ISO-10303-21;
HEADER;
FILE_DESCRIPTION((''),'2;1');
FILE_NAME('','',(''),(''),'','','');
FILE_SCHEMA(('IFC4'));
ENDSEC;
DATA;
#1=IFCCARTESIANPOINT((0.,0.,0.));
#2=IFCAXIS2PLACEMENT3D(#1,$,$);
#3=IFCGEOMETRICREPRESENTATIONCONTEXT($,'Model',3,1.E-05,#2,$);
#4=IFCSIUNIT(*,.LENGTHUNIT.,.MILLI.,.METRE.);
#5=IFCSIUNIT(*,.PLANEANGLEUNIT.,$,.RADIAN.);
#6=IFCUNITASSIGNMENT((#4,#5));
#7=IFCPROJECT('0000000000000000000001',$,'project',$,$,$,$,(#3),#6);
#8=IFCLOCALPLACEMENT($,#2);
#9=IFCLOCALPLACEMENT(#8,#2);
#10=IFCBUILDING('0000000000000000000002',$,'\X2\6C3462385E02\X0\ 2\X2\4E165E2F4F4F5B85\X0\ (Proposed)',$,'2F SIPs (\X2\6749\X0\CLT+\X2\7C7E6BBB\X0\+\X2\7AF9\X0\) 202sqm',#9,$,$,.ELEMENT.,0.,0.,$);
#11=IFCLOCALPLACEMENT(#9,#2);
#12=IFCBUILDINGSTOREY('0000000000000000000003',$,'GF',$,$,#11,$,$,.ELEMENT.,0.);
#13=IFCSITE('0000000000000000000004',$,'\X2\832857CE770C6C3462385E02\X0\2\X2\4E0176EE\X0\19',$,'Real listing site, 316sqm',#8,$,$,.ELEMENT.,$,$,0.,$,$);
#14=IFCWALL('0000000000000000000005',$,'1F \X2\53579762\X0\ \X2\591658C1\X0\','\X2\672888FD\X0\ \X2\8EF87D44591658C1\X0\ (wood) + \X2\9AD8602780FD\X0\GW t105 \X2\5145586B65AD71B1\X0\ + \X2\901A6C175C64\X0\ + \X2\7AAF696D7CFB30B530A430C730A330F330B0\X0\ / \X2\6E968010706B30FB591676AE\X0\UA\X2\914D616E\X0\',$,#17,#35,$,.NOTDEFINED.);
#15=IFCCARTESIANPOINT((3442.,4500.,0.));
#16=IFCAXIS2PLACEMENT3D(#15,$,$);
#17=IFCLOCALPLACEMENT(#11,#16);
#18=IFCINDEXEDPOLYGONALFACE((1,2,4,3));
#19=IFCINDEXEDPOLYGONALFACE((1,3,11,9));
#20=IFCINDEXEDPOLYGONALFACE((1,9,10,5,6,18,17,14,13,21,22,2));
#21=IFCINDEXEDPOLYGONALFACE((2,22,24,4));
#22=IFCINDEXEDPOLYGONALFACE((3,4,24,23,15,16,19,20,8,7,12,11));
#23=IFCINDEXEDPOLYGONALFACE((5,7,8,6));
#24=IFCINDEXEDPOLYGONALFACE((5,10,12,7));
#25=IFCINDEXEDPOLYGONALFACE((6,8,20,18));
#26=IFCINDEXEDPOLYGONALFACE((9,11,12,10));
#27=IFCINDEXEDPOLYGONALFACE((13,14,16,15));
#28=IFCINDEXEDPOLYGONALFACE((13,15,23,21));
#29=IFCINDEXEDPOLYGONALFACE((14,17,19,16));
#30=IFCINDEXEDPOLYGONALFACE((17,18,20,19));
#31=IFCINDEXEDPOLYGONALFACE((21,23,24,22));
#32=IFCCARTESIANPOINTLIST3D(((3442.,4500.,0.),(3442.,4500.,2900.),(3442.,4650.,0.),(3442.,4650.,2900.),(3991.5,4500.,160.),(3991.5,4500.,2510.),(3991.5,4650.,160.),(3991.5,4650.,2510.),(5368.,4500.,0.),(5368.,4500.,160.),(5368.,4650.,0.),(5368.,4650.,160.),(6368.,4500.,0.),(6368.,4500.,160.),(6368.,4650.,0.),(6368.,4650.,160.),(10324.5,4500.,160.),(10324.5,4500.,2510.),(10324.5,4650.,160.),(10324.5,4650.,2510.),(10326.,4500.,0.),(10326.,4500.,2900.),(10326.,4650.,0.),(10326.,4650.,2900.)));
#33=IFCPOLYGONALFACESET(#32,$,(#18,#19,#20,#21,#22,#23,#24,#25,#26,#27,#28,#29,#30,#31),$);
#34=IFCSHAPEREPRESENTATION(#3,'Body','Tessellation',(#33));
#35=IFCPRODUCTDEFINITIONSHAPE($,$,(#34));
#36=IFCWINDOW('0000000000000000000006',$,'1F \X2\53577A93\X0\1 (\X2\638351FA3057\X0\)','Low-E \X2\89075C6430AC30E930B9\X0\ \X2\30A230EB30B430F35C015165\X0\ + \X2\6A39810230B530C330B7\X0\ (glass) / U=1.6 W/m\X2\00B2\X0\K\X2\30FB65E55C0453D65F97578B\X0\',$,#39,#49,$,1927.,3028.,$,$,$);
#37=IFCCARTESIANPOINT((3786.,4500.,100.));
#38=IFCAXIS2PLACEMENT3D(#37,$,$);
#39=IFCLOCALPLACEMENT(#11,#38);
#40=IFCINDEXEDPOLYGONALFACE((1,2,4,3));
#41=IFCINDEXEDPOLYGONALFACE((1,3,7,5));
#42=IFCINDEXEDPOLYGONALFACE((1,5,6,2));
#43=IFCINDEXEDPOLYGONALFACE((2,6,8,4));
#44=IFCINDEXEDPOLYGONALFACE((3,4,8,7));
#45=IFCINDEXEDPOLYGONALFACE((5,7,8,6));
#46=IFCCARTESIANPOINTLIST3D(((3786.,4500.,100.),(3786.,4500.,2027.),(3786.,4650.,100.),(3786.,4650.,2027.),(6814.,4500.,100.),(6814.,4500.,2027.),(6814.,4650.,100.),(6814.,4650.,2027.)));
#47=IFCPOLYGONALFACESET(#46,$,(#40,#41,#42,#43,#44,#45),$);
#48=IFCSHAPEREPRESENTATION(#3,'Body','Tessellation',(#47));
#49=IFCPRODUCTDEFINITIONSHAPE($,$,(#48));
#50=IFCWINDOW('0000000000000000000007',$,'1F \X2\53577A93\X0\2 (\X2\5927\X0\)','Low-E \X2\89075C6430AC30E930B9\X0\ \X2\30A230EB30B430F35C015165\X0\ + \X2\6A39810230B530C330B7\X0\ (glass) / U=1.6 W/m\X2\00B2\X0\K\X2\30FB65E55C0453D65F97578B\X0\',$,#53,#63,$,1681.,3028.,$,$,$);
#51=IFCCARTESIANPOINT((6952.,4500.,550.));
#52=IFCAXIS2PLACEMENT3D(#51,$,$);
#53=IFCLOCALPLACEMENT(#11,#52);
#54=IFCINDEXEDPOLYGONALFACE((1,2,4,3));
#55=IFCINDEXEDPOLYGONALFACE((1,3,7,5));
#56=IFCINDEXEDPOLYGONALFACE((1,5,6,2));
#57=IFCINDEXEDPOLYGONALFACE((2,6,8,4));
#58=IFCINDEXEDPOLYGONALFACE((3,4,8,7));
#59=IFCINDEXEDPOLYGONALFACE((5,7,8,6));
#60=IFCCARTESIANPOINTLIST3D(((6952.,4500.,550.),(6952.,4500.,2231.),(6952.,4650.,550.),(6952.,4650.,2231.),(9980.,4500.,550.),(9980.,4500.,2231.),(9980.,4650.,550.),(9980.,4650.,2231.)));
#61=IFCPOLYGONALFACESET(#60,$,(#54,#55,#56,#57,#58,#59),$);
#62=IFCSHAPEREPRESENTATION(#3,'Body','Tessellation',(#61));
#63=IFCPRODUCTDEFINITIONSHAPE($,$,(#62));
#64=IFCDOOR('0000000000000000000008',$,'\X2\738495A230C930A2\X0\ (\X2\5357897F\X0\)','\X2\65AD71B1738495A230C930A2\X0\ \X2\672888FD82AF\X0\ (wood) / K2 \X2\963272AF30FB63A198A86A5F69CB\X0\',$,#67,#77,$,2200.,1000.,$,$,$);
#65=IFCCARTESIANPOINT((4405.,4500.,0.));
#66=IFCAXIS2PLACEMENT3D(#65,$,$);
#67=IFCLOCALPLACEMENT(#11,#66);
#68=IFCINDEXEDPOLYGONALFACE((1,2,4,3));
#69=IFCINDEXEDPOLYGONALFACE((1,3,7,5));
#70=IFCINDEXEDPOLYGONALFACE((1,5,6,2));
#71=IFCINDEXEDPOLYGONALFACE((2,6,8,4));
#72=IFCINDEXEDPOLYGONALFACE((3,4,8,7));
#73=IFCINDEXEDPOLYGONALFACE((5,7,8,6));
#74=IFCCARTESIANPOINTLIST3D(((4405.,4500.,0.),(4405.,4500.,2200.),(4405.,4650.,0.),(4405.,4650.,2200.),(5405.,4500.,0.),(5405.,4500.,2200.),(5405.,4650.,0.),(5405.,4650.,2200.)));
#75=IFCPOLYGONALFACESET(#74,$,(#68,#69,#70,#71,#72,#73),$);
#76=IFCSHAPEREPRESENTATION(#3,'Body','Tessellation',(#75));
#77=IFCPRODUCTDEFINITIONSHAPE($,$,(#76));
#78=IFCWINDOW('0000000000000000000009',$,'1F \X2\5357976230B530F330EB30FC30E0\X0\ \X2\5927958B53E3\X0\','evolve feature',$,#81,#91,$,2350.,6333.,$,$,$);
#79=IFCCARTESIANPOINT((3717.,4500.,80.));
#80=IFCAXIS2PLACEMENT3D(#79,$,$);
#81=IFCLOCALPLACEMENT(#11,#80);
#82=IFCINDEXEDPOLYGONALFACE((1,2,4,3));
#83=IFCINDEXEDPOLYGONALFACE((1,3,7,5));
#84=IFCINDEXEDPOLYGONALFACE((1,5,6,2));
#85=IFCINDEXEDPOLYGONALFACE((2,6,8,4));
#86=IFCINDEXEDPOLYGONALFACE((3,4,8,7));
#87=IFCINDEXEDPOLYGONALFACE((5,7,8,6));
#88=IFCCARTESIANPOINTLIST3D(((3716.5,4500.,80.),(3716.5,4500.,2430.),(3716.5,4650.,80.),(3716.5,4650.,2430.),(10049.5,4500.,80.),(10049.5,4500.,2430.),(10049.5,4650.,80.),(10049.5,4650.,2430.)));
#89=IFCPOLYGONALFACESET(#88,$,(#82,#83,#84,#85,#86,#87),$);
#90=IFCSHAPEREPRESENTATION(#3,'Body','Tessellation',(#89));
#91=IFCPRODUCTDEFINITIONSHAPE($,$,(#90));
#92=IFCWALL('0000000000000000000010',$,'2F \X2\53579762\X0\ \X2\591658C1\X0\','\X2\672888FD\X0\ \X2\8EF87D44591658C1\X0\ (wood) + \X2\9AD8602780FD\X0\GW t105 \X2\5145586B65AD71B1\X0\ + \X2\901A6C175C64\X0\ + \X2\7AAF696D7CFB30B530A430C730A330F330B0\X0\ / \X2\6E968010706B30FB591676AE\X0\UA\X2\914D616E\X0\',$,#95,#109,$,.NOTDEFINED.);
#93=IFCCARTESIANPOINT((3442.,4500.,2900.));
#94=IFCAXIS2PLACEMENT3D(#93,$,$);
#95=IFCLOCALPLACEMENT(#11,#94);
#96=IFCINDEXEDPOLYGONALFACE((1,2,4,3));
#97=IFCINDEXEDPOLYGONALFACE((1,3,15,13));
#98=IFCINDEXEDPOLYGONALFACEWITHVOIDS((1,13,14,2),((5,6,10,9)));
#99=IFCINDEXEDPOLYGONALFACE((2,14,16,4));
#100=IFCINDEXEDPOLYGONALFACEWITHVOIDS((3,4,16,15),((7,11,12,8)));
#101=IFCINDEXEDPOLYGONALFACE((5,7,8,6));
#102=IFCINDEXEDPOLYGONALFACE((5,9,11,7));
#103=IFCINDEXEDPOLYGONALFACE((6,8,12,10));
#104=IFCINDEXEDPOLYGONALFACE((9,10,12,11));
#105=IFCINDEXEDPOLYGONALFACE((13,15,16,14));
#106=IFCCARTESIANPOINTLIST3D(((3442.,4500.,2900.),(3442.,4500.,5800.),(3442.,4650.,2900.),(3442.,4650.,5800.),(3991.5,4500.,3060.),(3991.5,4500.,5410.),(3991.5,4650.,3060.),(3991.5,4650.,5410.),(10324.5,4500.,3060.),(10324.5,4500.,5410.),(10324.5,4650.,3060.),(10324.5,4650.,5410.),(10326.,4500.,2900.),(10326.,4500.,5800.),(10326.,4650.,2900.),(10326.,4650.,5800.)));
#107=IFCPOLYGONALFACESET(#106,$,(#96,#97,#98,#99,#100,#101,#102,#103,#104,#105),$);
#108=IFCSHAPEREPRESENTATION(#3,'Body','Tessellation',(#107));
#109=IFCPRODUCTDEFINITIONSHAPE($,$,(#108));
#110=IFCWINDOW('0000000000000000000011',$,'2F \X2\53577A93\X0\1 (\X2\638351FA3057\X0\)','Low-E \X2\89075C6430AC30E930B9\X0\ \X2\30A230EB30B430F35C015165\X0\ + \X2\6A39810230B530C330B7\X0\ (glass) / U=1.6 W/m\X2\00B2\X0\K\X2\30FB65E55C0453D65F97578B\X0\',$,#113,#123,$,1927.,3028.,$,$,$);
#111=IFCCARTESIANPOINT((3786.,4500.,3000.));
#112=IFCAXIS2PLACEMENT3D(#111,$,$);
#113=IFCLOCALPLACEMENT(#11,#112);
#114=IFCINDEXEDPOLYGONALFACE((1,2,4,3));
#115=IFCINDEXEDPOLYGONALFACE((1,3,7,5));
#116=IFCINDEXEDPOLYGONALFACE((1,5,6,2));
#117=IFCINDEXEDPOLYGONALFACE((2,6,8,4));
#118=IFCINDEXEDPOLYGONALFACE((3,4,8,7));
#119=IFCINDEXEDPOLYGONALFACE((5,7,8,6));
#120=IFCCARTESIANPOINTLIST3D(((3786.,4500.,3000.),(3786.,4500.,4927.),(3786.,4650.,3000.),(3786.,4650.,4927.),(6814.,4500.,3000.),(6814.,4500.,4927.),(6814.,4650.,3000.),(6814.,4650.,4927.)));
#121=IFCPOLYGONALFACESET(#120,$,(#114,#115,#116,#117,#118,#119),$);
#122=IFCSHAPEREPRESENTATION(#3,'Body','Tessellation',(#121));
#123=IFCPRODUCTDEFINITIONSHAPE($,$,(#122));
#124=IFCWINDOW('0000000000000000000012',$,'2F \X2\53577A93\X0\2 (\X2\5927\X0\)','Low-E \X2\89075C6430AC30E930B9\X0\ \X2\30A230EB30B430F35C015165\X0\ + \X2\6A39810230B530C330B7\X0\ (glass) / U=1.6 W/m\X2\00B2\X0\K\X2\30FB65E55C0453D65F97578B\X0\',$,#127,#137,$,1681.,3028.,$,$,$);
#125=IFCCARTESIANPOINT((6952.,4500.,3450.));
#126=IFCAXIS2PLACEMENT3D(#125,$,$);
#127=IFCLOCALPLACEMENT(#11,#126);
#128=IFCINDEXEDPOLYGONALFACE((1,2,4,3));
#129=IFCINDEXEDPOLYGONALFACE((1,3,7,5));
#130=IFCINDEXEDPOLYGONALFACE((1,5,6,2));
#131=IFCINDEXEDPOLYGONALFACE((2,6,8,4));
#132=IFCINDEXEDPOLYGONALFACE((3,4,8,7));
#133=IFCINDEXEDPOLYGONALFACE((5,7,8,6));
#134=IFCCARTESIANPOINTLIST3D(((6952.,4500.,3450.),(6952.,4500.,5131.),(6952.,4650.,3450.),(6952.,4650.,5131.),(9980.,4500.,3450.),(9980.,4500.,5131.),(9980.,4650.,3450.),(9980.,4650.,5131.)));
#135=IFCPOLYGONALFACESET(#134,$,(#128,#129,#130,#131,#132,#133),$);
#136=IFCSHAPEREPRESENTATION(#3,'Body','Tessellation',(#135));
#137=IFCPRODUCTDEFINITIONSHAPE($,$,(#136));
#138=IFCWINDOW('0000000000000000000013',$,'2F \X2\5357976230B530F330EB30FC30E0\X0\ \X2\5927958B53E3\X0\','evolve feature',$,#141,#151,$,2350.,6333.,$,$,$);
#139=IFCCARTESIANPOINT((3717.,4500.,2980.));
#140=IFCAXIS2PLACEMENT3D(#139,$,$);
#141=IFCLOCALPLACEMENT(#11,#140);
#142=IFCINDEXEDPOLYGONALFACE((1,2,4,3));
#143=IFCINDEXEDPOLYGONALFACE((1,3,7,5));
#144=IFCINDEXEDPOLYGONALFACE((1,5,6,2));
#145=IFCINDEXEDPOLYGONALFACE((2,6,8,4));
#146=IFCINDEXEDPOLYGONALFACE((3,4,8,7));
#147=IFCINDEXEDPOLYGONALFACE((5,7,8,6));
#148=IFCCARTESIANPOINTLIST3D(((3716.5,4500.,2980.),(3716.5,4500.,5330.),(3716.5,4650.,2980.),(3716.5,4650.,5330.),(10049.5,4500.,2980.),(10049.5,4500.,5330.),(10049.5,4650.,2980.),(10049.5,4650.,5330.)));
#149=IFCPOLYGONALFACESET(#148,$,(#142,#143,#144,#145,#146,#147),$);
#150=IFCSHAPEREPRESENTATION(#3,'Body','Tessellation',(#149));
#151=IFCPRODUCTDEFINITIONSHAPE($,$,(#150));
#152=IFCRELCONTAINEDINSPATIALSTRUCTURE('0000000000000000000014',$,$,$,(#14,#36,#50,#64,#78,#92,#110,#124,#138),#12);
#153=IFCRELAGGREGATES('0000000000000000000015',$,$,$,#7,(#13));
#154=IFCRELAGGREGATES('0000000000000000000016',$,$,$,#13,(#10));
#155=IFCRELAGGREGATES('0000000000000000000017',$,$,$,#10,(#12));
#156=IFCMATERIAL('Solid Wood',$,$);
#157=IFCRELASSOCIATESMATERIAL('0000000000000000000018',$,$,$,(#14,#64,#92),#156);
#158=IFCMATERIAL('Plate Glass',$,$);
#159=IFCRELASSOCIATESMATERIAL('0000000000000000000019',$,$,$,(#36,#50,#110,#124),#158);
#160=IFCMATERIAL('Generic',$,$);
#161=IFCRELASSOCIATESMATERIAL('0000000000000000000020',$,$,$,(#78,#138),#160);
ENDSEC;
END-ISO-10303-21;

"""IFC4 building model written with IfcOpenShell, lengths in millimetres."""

from ifc_helpers import new_model, si_unit, frame, frame_2d, origin, place, context, project, spatial, rectangle, extrude, material, element, fill, save


model = new_model("IFC4")

# Units and contexts
model_context = context("Model", 3, precision=1e-05, world=origin())
ifc_project = project(units=[si_unit("LENGTHUNIT", "METRE", prefix="MILLI"), si_unit("PLANEANGLEUNIT", "RADIAN")], contexts=[model_context])

# Site, building, storey
site_placement = place(None, origin())
site = spatial("IfcSite", under=ifc_project, at=site_placement, Name="茨城県水戸市2丁目19", ObjectType="Real listing site, 316sqm", CompositionType="ELEMENT", RefElevation=0.0)
building_placement = place(site_placement, origin())
building = spatial("IfcBuilding", under=site, at=building_placement, Name="水戸市 2世帯住宅 (Proposed)", ObjectType="2F SIPs (杉CLT+籾殻+竹) 202sqm", CompositionType="ELEMENT", ElevationOfRefHeight=0.0, ElevationOfTerrain=0.0)
storey_placement = place(building_placement, origin())
storey = spatial("IfcBuildingStorey", under=building, at=storey_placement, Name="GF", CompositionType="ELEMENT", Elevation=0.0)

# Shared definitions
ifc_material_1 = material(Name="Solid Wood")

# Wall, openings, windows, door
wall_1_placement = place(storey_placement, frame((3442.0, 4500.0, 0.0)))
wall_1 = element("IfcWall", 1, at=wall_1_placement, inside=storey, material=ifc_material_1, Name="1F 南面 外壁", Description="木製 軸組外壁 (wood) + 高性能GW t105 充填断熱 + 通気層 + 窯業系サイディング / 準耐火・外皮UA配慮", PredefinedType="NOTDEFINED", context=model_context, shape_type="SweptSolid", body=[
    extrude(rectangle(XDim=6884.0, YDim=150.0, at=frame_2d((3442.0, 75.0))), frame((3442.0, 4500.0, 0.0)), (0.0, 0.0, 1.0), 2900.0),
])
opening_1_placement = place(storey_placement, frame((3786.0, 4500.0, 100.0)))
opening_1 = element("IfcOpeningElement", 2, at=opening_1_placement, cuts=wall_1, PredefinedType="NOTDEFINED", context=model_context, shape_type="SweptSolid", body=[
    extrude(rectangle(XDim=3028.0, YDim=150.0, at=frame_2d((1514.0, 75.0))), frame((3786.0, 4500.0, 100.0)), (0.0, 0.0, 1.0), 1927.0),
])
opening_2_placement = place(storey_placement, frame((6952.0, 4500.0, 550.0)))
opening_2 = element("IfcOpeningElement", 3, at=opening_2_placement, cuts=wall_1, PredefinedType="NOTDEFINED", context=model_context, shape_type="SweptSolid", body=[
    extrude(rectangle(XDim=3028.0, YDim=150.0, at=frame_2d((1514.0, 75.0))), frame((6952.0, 4500.0, 550.0)), (0.0, 0.0, 1.0), 1681.0),
])
opening_3_placement = place(storey_placement, frame((4405.0, 4500.0, 0.0)))
opening_3 = element("IfcOpeningElement", 4, at=opening_3_placement, cuts=wall_1, PredefinedType="NOTDEFINED", context=model_context, shape_type="SweptSolid", body=[
    extrude(rectangle(XDim=1000.0, YDim=150.0, at=frame_2d((500.0, 75.0))), frame((4405.0, 4500.0, 0.0)), (0.0, 0.0, 1.0), 2200.0),
])
opening_4_placement = place(storey_placement, frame((3717.0, 4500.0, 80.0)))
opening_4 = element("IfcOpeningElement", 5, at=opening_4_placement, cuts=wall_1, PredefinedType="NOTDEFINED", context=model_context, shape_type="SweptSolid", body=[
    extrude(rectangle(XDim=6333.0, YDim=150.0, at=frame_2d((3166.0, 75.0))), frame((3717.0, 4500.0, 80.0)), (0.0, 0.0, 1.0), 2350.0),
])
ifc_material_2 = material(Name="Plate Glass")
window_1_placement = place(storey_placement, frame((3786.0, 4500.0, 100.0)))
window_1 = element("IfcWindow", 6, at=window_1_placement, inside=storey, material=ifc_material_2, Name="1F 南窓1 (掃出し)", Description="Low-E 複層ガラス アルゴン封入 + 樹脂サッシ (glass) / U=1.6 W/m²K・日射取得型", OverallHeight=1927.0, OverallWidth=3028.0, context=model_context, shape_type="SweptSolid", body=[
    extrude(rectangle(XDim=3028.0, YDim=150.0, at=frame_2d((1514.0, 75.0))), frame((3786.0, 4500.0, 100.0)), (0.0, 0.0, 1.0), 1927.0),
])
fill(opening_1, window_1)
window_2_placement = place(storey_placement, frame((6952.0, 4500.0, 550.0)))
window_2 = element("IfcWindow", 7, at=window_2_placement, inside=storey, material=ifc_material_2, Name="1F 南窓2 (大)", Description="Low-E 複層ガラス アルゴン封入 + 樹脂サッシ (glass) / U=1.6 W/m²K・日射取得型", OverallHeight=1681.0, OverallWidth=3028.0, context=model_context, shape_type="SweptSolid", body=[
    extrude(rectangle(XDim=3028.0, YDim=150.0, at=frame_2d((1514.0, 75.0))), frame((6952.0, 4500.0, 550.0)), (0.0, 0.0, 1.0), 1681.0),
])
fill(opening_2, window_2)
door_placement = place(storey_placement, frame((4405.0, 4500.0, 0.0)))
door = element("IfcDoor", 8, at=door_placement, inside=storey, material=ifc_material_1, Name="玄関ドア (南西)", Description="断熱玄関ドア 木製芯 (wood) / K2 防犯・採風機構", OverallHeight=2200.0, OverallWidth=1000.0, context=model_context, shape_type="SweptSolid", body=[
    extrude(rectangle(XDim=1000.0, YDim=150.0, at=frame_2d((500.0, 75.0))), frame((4405.0, 4500.0, 0.0)), (0.0, 0.0, 1.0), 2200.0),
])
fill(opening_3, door)
ifc_material_3 = material(Name="Generic")
window_3_placement = place(storey_placement, frame((3717.0, 4500.0, 80.0)))
window_3 = element("IfcWindow", 9, at=window_3_placement, inside=storey, material=ifc_material_3, Name="1F 南面サンルーム 大開口", Description="evolve feature", OverallHeight=2350.0, OverallWidth=6333.0, context=model_context, shape_type="SweptSolid", body=[
    extrude(rectangle(XDim=6333.0, YDim=150.0, at=frame_2d((3166.0, 75.0))), frame((3717.0, 4500.0, 80.0)), (0.0, 0.0, 1.0), 2350.0),
])
fill(opening_4, window_3)

# Wall, openings, windows
wall_2_placement = place(storey_placement, frame((3442.0, 4500.0, 2900.0)))
wall_2 = element("IfcWall", 10, at=wall_2_placement, inside=storey, material=ifc_material_1, Name="2F 南面 外壁", Description="木製 軸組外壁 (wood) + 高性能GW t105 充填断熱 + 通気層 + 窯業系サイディング / 準耐火・外皮UA配慮", PredefinedType="NOTDEFINED", context=model_context, shape_type="SweptSolid", body=[
    extrude(rectangle(XDim=6884.0, YDim=150.0, at=frame_2d((3442.0, 75.0))), frame((3442.0, 4500.0, 2900.0)), (0.0, 0.0, 1.0), 2900.0),
])
opening_5_placement = place(storey_placement, frame((3786.0, 4500.0, 3000.0)))
opening_5 = element("IfcOpeningElement", 11, at=opening_5_placement, cuts=wall_2, PredefinedType="NOTDEFINED", context=model_context, shape_type="SweptSolid", body=[
    extrude(rectangle(XDim=3028.0, YDim=150.0, at=frame_2d((1514.0, 75.0))), frame((3786.0, 4500.0, 3000.0)), (0.0, 0.0, 1.0), 1927.0),
])
opening_6_placement = place(storey_placement, frame((6952.0, 4500.0, 3450.0)))
opening_6 = element("IfcOpeningElement", 12, at=opening_6_placement, cuts=wall_2, PredefinedType="NOTDEFINED", context=model_context, shape_type="SweptSolid", body=[
    extrude(rectangle(XDim=3028.0, YDim=150.0, at=frame_2d((1514.0, 75.0))), frame((6952.0, 4500.0, 3450.0)), (0.0, 0.0, 1.0), 1681.0),
])
opening_7_placement = place(storey_placement, frame((3717.0, 4500.0, 2980.0)))
opening_7 = element("IfcOpeningElement", 13, at=opening_7_placement, cuts=wall_2, PredefinedType="NOTDEFINED", context=model_context, shape_type="SweptSolid", body=[
    extrude(rectangle(XDim=6333.0, YDim=150.0, at=frame_2d((3166.0, 75.0))), frame((3717.0, 4500.0, 2980.0)), (0.0, 0.0, 1.0), 2350.0),
])
window_4_placement = place(storey_placement, frame((3786.0, 4500.0, 3000.0)))
window_4 = element("IfcWindow", 14, at=window_4_placement, inside=storey, material=ifc_material_2, Name="2F 南窓1 (掃出し)", Description="Low-E 複層ガラス アルゴン封入 + 樹脂サッシ (glass) / U=1.6 W/m²K・日射取得型", OverallHeight=1927.0, OverallWidth=3028.0, context=model_context, shape_type="SweptSolid", body=[
    extrude(rectangle(XDim=3028.0, YDim=150.0, at=frame_2d((1514.0, 75.0))), frame((3786.0, 4500.0, 3000.0)), (0.0, 0.0, 1.0), 1927.0),
])
fill(opening_5, window_4)
window_5_placement = place(storey_placement, frame((6952.0, 4500.0, 3450.0)))
window_5 = element("IfcWindow", 15, at=window_5_placement, inside=storey, material=ifc_material_2, Name="2F 南窓2 (大)", Description="Low-E 複層ガラス アルゴン封入 + 樹脂サッシ (glass) / U=1.6 W/m²K・日射取得型", OverallHeight=1681.0, OverallWidth=3028.0, context=model_context, shape_type="SweptSolid", body=[
    extrude(rectangle(XDim=3028.0, YDim=150.0, at=frame_2d((1514.0, 75.0))), frame((6952.0, 4500.0, 3450.0)), (0.0, 0.0, 1.0), 1681.0),
])
fill(opening_6, window_5)
window_6_placement = place(storey_placement, frame((3717.0, 4500.0, 2980.0)))
window_6 = element("IfcWindow", 16, at=window_6_placement, inside=storey, material=ifc_material_3, Name="2F 南面サンルーム 大開口", Description="evolve feature", OverallHeight=2350.0, OverallWidth=6333.0, context=model_context, shape_type="SweptSolid", body=[
    extrude(rectangle(XDim=6333.0, YDim=150.0, at=frame_2d((3166.0, 75.0))), frame((3717.0, 4500.0, 2980.0)), (0.0, 0.0, 1.0), 2350.0),
])
fill(opening_7, window_6)

save(model, "model.ifc")
